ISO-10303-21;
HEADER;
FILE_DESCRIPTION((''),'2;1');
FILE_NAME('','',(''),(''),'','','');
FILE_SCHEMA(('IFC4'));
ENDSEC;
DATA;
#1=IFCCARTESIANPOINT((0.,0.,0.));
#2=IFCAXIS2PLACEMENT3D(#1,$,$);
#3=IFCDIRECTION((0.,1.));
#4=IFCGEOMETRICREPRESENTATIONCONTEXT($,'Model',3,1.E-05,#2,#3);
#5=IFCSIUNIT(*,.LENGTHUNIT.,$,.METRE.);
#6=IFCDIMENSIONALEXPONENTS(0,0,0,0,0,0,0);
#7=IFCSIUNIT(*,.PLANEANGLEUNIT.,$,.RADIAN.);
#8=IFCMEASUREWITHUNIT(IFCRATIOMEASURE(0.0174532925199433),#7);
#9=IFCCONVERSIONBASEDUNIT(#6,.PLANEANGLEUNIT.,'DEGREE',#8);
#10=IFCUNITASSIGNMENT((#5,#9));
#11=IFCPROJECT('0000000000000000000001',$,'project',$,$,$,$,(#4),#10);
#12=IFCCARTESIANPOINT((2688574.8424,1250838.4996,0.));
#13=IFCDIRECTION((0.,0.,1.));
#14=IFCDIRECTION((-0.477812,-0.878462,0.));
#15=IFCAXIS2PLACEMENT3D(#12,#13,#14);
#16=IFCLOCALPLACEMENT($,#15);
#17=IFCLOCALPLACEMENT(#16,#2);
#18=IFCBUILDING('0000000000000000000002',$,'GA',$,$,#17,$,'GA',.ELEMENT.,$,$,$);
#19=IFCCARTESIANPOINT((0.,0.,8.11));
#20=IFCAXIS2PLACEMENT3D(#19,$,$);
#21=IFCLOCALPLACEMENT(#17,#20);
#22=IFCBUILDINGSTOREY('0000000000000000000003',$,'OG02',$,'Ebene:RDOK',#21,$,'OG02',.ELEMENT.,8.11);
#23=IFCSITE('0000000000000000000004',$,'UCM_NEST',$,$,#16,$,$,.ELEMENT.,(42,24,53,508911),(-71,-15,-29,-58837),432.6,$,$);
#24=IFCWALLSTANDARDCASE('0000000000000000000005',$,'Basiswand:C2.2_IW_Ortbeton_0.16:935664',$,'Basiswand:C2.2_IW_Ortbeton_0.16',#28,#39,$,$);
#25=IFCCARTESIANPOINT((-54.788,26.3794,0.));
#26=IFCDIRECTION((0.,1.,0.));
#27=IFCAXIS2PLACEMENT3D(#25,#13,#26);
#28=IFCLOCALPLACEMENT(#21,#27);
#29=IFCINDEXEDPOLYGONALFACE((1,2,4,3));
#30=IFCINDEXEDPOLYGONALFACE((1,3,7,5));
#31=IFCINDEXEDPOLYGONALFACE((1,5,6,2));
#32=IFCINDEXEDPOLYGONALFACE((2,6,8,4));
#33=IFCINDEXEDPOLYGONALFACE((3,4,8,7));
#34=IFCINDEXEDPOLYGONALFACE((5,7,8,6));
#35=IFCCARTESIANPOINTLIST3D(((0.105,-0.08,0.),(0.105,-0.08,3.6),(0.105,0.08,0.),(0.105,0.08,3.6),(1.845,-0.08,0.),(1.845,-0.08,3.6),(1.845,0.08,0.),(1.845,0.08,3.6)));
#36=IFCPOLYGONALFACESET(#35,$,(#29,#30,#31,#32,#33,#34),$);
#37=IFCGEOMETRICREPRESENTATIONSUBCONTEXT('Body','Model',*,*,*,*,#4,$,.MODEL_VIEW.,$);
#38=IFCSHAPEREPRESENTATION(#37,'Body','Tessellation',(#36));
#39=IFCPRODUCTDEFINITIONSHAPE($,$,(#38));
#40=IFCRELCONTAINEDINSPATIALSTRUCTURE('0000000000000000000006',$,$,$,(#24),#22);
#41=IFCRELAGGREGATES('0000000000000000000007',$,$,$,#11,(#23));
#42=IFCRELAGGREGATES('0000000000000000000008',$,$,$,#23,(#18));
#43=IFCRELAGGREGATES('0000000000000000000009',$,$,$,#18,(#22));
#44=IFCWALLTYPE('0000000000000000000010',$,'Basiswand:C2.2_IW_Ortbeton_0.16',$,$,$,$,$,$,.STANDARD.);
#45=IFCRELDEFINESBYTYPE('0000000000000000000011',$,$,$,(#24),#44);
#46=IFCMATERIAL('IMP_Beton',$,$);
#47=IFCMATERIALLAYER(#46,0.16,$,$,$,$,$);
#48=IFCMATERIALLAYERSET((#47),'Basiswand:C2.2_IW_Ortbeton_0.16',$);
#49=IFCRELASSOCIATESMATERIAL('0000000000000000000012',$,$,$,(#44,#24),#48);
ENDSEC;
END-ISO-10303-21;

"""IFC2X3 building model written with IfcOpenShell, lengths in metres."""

from ifc_helpers import new_model, entity, si_unit, converted_unit, direction, frame, frame_2d, origin, place, context, subcontext, project, spatial, rectangle, extrude, material, layer, layer_set, layer_usage, type_object, element, save


model = new_model("IFC2X3")

# Units and contexts
model_context = context("Model", 3, precision=1e-05, world=origin(), true_north=direction((0.0, 1.0)))
body_context = subcontext(model_context, "Body", "Model", "MODEL_VIEW")
ifc_project = project(units=[si_unit("LENGTHUNIT", "METRE"), converted_unit("PLANEANGLEUNIT", "DEGREE", entity("IfcRatioMeasure", 0.0174532925199433), si_unit("PLANEANGLEUNIT", "RADIAN"), dimensions=[0, 0, 0, 0, 0, 0, 0])], contexts=[model_context])

# Site, building, storey
site_placement = place(None, frame((2688574.8424, 1250838.4996, 0.0), z_axis=(0.0, 0.0, 1.0), x_axis=(-0.477812, -0.878462, 0.0)))
site = spatial("IfcSite", under=ifc_project, at=site_placement, Name="UCM_NEST", CompositionType="ELEMENT", RefLatitude=(42, 24, 53, 508911), RefLongitude=(-71, -15, -29, -58837), RefElevation=432.6)
building_placement = place(site_placement, origin())
building = spatial("IfcBuilding", under=site, at=building_placement, Name="GA", LongName="GA", CompositionType="ELEMENT")
storey_placement = place(building_placement, frame((0.0, 0.0, 8.11)))
storey = spatial("IfcBuildingStorey", under=building, at=storey_placement, Name="OG02", ObjectType="Ebene:RDOK", LongName="OG02", CompositionType="ELEMENT", Elevation=8.11)

# Shared definitions
ifc_material_1 = material(Name="IMP_Beton")

# Wall
ifc_layer_1 = layer(ifc_material_1, 0.16)
ifc_layer_set_1 = layer_set([ifc_layer_1], Name="Basiswand:C2.2_IW_Ortbeton_0.16")
ifc_layer_usage_1 = layer_usage(ifc_layer_set_1, "AXIS2", "NEGATIVE", 0.08)
wall_type_1 = type_object("IfcWallType", Name="Basiswand:C2.2_IW_Ortbeton_0.16", PredefinedType="STANDARD", material=ifc_layer_set_1)
wall_1_placement = place(storey_placement, frame((-54.788, 26.3794, 0.0), z_axis=(0.0, 0.0, 1.0), x_axis=(0.0, 1.0, 0.0)))
element("IfcWallStandardCase", 1, at=wall_1_placement, inside=storey, type_object=wall_type_1, material=ifc_layer_usage_1, Name="Basiswand:C2.2_IW_Ortbeton_0.16:935664", ObjectType="Basiswand:C2.2_IW_Ortbeton_0.16", context=body_context, shape_type="SweptSolid", body=[
    extrude(rectangle(XDim=1.74, YDim=0.16, at=frame_2d((0.975, 0.0), x_axis=(-1.0, 0.0))), origin(), (0.0, 0.0, 1.0), 3.6),
])

save(model, "model.ifc")
